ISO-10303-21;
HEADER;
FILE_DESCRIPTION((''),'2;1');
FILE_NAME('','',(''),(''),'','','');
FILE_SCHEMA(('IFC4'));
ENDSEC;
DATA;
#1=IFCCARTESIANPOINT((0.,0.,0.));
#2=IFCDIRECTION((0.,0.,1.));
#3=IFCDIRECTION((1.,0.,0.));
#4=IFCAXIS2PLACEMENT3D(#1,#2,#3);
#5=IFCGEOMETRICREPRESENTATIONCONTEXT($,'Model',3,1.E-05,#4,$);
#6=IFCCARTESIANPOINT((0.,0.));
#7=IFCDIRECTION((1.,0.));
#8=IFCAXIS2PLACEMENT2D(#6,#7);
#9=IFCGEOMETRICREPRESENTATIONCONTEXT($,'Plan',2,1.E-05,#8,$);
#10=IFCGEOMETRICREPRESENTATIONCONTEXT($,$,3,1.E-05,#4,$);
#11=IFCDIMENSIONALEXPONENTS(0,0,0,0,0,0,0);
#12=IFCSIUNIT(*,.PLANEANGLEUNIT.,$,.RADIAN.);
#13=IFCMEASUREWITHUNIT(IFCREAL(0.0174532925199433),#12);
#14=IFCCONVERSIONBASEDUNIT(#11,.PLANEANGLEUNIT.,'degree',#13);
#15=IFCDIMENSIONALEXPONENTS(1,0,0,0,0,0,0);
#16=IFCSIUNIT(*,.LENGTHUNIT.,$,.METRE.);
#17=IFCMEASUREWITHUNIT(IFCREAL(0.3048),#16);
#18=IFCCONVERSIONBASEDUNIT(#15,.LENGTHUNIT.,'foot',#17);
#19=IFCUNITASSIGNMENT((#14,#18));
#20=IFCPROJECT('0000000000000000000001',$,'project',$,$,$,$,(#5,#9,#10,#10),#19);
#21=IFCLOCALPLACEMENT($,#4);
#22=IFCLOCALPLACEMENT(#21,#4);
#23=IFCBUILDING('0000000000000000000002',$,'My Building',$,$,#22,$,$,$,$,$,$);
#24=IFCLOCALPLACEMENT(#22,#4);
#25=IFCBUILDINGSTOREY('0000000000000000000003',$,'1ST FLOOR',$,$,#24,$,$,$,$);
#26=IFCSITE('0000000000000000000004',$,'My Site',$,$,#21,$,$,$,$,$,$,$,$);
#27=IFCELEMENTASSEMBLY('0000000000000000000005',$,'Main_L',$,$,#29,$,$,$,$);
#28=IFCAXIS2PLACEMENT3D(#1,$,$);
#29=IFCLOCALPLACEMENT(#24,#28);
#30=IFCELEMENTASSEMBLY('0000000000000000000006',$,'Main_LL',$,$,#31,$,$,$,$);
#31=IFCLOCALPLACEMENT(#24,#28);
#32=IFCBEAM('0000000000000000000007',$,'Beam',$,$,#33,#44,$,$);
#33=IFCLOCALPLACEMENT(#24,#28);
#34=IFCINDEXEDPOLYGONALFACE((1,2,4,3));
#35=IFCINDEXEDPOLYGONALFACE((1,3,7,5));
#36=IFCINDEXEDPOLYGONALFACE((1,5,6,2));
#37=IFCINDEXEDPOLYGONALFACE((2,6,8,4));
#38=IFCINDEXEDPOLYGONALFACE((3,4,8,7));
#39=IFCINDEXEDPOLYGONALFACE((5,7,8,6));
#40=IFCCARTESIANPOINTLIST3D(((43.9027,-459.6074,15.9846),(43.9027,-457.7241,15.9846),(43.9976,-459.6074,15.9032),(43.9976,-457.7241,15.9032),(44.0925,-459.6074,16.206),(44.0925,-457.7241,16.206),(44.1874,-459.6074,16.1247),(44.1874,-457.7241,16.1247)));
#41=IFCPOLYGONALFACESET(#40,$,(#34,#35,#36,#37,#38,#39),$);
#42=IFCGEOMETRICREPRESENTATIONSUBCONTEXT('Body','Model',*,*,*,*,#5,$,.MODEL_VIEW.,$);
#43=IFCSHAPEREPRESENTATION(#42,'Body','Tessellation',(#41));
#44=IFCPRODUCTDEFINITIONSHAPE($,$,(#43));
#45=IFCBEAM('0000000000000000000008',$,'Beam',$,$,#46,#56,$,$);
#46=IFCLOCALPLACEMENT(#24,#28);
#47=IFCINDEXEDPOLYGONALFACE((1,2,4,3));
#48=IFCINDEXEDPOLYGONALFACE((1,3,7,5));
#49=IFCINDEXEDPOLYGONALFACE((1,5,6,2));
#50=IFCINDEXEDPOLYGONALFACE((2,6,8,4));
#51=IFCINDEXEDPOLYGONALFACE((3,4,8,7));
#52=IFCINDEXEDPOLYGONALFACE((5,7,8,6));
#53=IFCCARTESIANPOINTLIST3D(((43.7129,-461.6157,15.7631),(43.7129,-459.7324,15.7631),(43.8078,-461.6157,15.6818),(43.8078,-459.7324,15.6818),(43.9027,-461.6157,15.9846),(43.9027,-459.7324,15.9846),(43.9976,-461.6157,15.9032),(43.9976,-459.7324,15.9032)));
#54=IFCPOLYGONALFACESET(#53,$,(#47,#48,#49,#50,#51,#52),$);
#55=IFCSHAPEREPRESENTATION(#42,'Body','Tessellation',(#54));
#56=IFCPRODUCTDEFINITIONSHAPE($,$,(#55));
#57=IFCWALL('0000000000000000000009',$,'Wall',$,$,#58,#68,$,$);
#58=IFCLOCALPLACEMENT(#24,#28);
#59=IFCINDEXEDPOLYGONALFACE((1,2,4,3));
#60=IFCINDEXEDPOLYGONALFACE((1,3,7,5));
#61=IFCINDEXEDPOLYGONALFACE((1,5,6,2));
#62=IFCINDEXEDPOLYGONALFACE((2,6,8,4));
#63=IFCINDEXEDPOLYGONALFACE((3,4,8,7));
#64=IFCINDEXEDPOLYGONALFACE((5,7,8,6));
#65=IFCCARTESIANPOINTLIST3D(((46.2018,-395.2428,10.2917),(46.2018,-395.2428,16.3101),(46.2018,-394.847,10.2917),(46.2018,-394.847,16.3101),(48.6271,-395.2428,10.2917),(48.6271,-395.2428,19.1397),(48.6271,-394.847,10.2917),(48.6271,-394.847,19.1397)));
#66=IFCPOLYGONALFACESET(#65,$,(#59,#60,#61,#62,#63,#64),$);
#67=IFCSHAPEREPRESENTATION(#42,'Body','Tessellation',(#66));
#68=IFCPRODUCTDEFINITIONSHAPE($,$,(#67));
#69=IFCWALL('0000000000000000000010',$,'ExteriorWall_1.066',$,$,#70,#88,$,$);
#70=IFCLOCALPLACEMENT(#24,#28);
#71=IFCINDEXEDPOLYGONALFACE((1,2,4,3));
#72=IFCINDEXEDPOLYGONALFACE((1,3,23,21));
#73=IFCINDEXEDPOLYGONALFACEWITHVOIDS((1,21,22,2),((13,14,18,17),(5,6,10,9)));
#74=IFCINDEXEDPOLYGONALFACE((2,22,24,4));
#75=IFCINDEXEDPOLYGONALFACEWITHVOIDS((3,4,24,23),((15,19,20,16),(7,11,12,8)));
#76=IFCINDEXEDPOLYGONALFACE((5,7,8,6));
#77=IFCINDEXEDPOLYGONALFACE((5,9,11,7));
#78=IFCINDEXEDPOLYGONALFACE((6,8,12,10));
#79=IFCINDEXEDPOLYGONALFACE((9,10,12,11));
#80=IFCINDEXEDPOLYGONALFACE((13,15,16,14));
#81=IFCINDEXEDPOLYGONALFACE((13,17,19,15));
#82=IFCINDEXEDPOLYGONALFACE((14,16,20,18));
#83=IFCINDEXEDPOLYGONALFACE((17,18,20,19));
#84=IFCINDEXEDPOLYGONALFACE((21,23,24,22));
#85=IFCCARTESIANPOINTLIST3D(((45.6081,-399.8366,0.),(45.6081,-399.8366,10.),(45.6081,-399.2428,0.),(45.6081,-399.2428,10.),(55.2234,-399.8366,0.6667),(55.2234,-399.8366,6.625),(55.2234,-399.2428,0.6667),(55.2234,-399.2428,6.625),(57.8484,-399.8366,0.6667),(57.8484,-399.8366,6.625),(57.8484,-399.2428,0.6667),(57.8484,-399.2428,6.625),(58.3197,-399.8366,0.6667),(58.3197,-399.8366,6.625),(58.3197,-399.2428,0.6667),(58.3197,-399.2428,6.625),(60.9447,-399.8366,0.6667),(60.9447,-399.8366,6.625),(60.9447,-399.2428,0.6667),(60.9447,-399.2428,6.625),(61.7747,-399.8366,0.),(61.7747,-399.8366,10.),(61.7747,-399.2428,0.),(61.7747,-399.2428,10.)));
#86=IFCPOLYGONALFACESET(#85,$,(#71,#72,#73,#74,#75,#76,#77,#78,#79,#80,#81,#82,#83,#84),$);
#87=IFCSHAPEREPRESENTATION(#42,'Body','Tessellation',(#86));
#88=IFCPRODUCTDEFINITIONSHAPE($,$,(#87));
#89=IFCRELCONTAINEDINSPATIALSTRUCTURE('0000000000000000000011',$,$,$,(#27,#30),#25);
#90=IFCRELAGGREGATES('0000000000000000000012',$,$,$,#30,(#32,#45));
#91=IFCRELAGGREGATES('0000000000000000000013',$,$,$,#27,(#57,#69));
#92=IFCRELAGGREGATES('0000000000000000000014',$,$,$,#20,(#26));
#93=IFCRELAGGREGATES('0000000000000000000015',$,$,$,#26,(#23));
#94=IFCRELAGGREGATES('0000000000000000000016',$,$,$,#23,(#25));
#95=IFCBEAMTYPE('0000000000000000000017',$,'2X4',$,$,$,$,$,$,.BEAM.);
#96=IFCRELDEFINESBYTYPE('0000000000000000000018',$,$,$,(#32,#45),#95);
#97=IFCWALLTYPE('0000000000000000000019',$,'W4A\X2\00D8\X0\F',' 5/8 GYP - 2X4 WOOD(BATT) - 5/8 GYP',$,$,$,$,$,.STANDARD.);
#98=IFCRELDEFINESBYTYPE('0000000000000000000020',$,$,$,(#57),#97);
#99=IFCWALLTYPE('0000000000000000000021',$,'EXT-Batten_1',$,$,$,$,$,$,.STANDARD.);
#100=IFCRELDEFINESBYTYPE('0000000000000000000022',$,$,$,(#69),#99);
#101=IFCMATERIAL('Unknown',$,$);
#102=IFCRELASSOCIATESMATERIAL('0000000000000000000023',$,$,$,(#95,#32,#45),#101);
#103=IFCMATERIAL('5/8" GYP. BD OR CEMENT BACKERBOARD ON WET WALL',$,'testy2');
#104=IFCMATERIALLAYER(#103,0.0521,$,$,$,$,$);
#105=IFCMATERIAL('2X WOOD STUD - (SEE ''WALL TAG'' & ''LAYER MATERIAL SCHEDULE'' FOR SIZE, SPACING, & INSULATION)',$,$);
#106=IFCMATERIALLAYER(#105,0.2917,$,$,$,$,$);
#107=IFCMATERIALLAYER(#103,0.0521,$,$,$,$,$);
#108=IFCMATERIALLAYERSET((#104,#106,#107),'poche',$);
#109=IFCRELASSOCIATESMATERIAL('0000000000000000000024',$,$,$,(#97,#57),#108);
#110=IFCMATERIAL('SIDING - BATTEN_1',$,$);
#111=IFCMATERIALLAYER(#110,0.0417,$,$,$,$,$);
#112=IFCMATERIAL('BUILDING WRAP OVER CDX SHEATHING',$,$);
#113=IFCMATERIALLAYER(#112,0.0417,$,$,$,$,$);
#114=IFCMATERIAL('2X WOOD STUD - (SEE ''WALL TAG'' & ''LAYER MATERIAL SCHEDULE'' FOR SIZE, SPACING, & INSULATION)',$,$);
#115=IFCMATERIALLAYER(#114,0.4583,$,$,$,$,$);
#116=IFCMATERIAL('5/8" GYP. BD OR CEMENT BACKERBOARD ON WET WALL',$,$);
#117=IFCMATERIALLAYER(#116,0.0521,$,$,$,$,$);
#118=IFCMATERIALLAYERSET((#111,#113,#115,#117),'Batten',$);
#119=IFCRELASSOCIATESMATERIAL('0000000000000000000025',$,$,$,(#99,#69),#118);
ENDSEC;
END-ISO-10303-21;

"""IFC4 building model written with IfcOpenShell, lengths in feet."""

from ifc_helpers import new_model, entity, si_unit, converted_unit, frame, origin_with_axes, origin_2d_with_axis, place, context, subcontext, project, spatial, line, indexed_curve, rectangle, outline, extrude, clip, halfspace, source, transform, mapped, material, layer, layer_set, layer_usage, material_profile, profile_set, profile_usage, type_object, element, aggregate, save


model = new_model("IFC4")

# Units and contexts
model_context = context("Model", 3, precision=1e-05, world=origin_with_axes())
plan_context = context("Plan", 2, precision=1e-05, world=origin_2d_with_axis())
context_of_model = context(None, 3, precision=1e-05, world=origin_with_axes())
body_context = subcontext(model_context, "Body", "Model", "MODEL_VIEW")
ifc_project = project(units=[converted_unit("PLANEANGLEUNIT", "degree", entity("IfcReal", 0.0174532925199433), si_unit("PLANEANGLEUNIT", "RADIAN"), dimensions=[0, 0, 0, 0, 0, 0, 0]), converted_unit("LENGTHUNIT", "foot", entity("IfcReal", 0.3048), si_unit("LENGTHUNIT", "METRE"), dimensions=[1, 0, 0, 0, 0, 0, 0])], contexts=[model_context, plan_context, context_of_model, context_of_model])

# Site, building, storey
site_placement = place(None, origin_with_axes())
site = spatial("IfcSite", under=ifc_project, at=site_placement, Name="My Site")
building_placement = place(site_placement, origin_with_axes())
building = spatial("IfcBuilding", under=site, at=building_placement, Name="My Building")
storey_placement = place(building_placement, origin_with_axes())
storey = spatial("IfcBuildingStorey", under=building, at=storey_placement, Name="1ST FLOOR")

# Element assemblies
assembly_1_placement = place(storey_placement, origin_with_axes())
assembly_1 = element("IfcElementAssembly", 1, at=assembly_1_placement, inside=storey, Name="Main_L")
assembly_2_placement = place(storey_placement, origin_with_axes())
assembly_2 = element("IfcElementAssembly", 2, at=assembly_2_placement, inside=storey, Name="Main_LL")

# Beams
ifc_material_1 = material(Name="Unknown")
ifc_material_profile_1 = material_profile(ifc_material_1, rectangle(XDim=0.125, YDim=0.2917))
ifc_profile_set_1 = profile_set([ifc_material_profile_1])
beam_type_1 = type_object("IfcBeamType", Name="2X4", PredefinedType="BEAM", material=ifc_profile_set_1)
ifc_profile_usage_1 = profile_usage(ifc_profile_set_1, cardinal=5)
beam_1_placement = place(assembly_2_placement, frame((44.045, -457.7241, 16.0546), z_axis=(0.0, -1.0, 0.0), x_axis=(-0.759271, 0.0, 0.650774)))
beam_1 = element("IfcBeam", 3, at=beam_1_placement, type_object=beam_type_1, material=ifc_profile_usage_1, Name="Beam", context=body_context, shape_type="SweptSolid", body=[
    extrude(rectangle(XDim=0.125, YDim=0.2917), origin_with_axes(), (0.0, 0.0, 1.0), 1.8833),
])
ifc_profile_usage_2 = profile_usage(ifc_profile_set_1, cardinal=5)
beam_2_placement = place(assembly_2_placement, frame((43.8552, -459.7324, 15.8332), z_axis=(0.0, -1.0, 0.0), x_axis=(-0.759271, 0.0, 0.650774)))
beam_2 = element("IfcBeam", 4, at=beam_2_placement, type_object=beam_type_1, material=ifc_profile_usage_2, Name="Beam", context=body_context, shape_type="SweptSolid", body=[
    extrude(rectangle(XDim=0.125, YDim=0.2917), origin_with_axes(), (0.0, 0.0, 1.0), 1.8833),
])
aggregate(assembly_2, [beam_1, beam_2])

# Wall
ifc_material_2 = material(Name="5/8\" GYP. BD OR CEMENT BACKERBOARD ON WET WALL", Category="testy2")
ifc_layer_1 = layer(ifc_material_2, 0.0521)
ifc_material_3 = material(Name="2X WOOD STUD - (SEE 'WALL TAG' & 'LAYER MATERIAL SCHEDULE' FOR SIZE, SPACING, & INSULATION)")
ifc_layer_2 = layer(ifc_material_3, 0.2917)
ifc_layer_3 = layer(ifc_material_2, 0.0521)
ifc_layer_set_1 = layer_set([ifc_layer_1, ifc_layer_2, ifc_layer_3], Name="poche")
ifc_layer_usage_1 = layer_usage(ifc_layer_set_1, "AXIS2", "POSITIVE", 0.0)
wall_type_1 = type_object("IfcWallType", Name="W4AØF", Description=" 5/8 GYP - 2X4 WOOD(BATT) - 5/8 GYP", PredefinedType="STANDARD", material=ifc_layer_set_1)
wall_1_placement = place(assembly_1_placement, frame((46.2018, -395.2428, 10.2917), z_axis=(0.0, 0.0, 1.0), x_axis=(1.0, 0.0, 0.0)))
wall_1 = element("IfcWall", 5, at=wall_1_placement, type_object=wall_type_1, material=ifc_layer_usage_1, Name="Wall", context=body_context, shape_type="Clipping", body=[
    clip(extrude(outline(indexed_curve([(0.0, 0.0), (0.0, 0.3958), (2.4253, 0.3958), (2.4253, 0.0), (0.0, 0.0)], self_intersect=False)), origin_with_axes(), (0.0, 0.0, 1.0), 19.1397), halfspace(frame((2.4253, 0.0, 8.8481), z_axis=(-0.759271, 0.0, 0.650774), x_axis=(0.0, 1.0, 0.0)), False)),
])

# Wall, openings
ifc_material_4 = material(Name="SIDING - BATTEN_1")
ifc_layer_4 = layer(ifc_material_4, 0.0417)
ifc_material_5 = material(Name="BUILDING WRAP OVER CDX SHEATHING")
ifc_layer_5 = layer(ifc_material_5, 0.0417)
ifc_material_6 = material(Name="2X WOOD STUD - (SEE 'WALL TAG' & 'LAYER MATERIAL SCHEDULE' FOR SIZE, SPACING, & INSULATION)")
ifc_layer_6 = layer(ifc_material_6, 0.4583)
ifc_material_7 = material(Name="5/8\" GYP. BD OR CEMENT BACKERBOARD ON WET WALL")
ifc_layer_7 = layer(ifc_material_7, 0.0521)
ifc_layer_set_2 = layer_set([ifc_layer_4, ifc_layer_5, ifc_layer_6, ifc_layer_7], Name="Batten")
ifc_layer_usage_2 = layer_usage(ifc_layer_set_2, "AXIS2", "POSITIVE", 0.0)
wall_type_2 = type_object("IfcWallType", Name="EXT-Batten_1", PredefinedType="STANDARD", material=ifc_layer_set_2)
wall_2_placement = place(assembly_1_placement, frame((45.6081, -399.8366, 0.0), z_axis=(0.0, 0.0, 1.0), x_axis=(1.0, 0.0, 0.0)))
wall_2 = element("IfcWall", 6, at=wall_2_placement, type_object=wall_type_2, material=ifc_layer_usage_2, Name="ExteriorWall_1.066", context=body_context, shape_type="SweptSolid", body=[
    extrude(outline(indexed_curve([(0.0, 0.0), (0.0, 0.5938), (16.1666, 0.5938), (16.1666, 0.0), (0.0, 0.0)], self_intersect=False)), origin_with_axes(), (0.0, 0.0, 1.0), 10.0),
])
shared_shape = source(origin_with_axes(), body_context, "Body", "SweptSolid", [
    extrude(outline(indexed_curve([(0.0, 0.0), (2.625, 0.0), (2.625, 5.9583), (0.0, 5.9583)], segments=[line(1, 2, 3, 4, 1)])), frame((0.0, -1.9685, 0.0), z_axis=(0.0, -1.0, 0.0), x_axis=(1.0, 0.0, 0.0)), (0.0, 0.0, -1.0), 3.937),
])
opening_1_placement = place(wall_2_placement, frame((9.6153, 0.0, 0.6667), z_axis=(0.0, 0.0, 1.0), x_axis=(1.0, 0.0, 0.0)))
element("IfcOpeningElement", 7, at=opening_1_placement, cuts=wall_2, PredefinedType="OPENING", context=body_context, shape_type="MappedRepresentation", body=[
    mapped(shared_shape, transform((0.0, 0.0, 0.0), x_axis=(1.0, 0.0, 0.0), y_axis=(0.0, 1.0, 0.0), z_axis=(0.0, 0.0, 1.0), scale=1.0)),
])
opening_2_placement = place(wall_2_placement, frame((12.7116, 0.0, 0.6667), z_axis=(0.0, 0.0, 1.0), x_axis=(1.0, 0.0, 0.0)))
element("IfcOpeningElement", 8, at=opening_2_placement, cuts=wall_2, PredefinedType="OPENING", context=body_context, shape_type="MappedRepresentation", body=[
    mapped(shared_shape, transform((0.0, 0.0, 0.0), x_axis=(1.0, 0.0, 0.0), y_axis=(0.0, 1.0, 0.0), z_axis=(0.0, 0.0, 1.0), scale=1.0)),
])
aggregate(assembly_1, [wall_1, wall_2])

save(model, "model.ifc")
